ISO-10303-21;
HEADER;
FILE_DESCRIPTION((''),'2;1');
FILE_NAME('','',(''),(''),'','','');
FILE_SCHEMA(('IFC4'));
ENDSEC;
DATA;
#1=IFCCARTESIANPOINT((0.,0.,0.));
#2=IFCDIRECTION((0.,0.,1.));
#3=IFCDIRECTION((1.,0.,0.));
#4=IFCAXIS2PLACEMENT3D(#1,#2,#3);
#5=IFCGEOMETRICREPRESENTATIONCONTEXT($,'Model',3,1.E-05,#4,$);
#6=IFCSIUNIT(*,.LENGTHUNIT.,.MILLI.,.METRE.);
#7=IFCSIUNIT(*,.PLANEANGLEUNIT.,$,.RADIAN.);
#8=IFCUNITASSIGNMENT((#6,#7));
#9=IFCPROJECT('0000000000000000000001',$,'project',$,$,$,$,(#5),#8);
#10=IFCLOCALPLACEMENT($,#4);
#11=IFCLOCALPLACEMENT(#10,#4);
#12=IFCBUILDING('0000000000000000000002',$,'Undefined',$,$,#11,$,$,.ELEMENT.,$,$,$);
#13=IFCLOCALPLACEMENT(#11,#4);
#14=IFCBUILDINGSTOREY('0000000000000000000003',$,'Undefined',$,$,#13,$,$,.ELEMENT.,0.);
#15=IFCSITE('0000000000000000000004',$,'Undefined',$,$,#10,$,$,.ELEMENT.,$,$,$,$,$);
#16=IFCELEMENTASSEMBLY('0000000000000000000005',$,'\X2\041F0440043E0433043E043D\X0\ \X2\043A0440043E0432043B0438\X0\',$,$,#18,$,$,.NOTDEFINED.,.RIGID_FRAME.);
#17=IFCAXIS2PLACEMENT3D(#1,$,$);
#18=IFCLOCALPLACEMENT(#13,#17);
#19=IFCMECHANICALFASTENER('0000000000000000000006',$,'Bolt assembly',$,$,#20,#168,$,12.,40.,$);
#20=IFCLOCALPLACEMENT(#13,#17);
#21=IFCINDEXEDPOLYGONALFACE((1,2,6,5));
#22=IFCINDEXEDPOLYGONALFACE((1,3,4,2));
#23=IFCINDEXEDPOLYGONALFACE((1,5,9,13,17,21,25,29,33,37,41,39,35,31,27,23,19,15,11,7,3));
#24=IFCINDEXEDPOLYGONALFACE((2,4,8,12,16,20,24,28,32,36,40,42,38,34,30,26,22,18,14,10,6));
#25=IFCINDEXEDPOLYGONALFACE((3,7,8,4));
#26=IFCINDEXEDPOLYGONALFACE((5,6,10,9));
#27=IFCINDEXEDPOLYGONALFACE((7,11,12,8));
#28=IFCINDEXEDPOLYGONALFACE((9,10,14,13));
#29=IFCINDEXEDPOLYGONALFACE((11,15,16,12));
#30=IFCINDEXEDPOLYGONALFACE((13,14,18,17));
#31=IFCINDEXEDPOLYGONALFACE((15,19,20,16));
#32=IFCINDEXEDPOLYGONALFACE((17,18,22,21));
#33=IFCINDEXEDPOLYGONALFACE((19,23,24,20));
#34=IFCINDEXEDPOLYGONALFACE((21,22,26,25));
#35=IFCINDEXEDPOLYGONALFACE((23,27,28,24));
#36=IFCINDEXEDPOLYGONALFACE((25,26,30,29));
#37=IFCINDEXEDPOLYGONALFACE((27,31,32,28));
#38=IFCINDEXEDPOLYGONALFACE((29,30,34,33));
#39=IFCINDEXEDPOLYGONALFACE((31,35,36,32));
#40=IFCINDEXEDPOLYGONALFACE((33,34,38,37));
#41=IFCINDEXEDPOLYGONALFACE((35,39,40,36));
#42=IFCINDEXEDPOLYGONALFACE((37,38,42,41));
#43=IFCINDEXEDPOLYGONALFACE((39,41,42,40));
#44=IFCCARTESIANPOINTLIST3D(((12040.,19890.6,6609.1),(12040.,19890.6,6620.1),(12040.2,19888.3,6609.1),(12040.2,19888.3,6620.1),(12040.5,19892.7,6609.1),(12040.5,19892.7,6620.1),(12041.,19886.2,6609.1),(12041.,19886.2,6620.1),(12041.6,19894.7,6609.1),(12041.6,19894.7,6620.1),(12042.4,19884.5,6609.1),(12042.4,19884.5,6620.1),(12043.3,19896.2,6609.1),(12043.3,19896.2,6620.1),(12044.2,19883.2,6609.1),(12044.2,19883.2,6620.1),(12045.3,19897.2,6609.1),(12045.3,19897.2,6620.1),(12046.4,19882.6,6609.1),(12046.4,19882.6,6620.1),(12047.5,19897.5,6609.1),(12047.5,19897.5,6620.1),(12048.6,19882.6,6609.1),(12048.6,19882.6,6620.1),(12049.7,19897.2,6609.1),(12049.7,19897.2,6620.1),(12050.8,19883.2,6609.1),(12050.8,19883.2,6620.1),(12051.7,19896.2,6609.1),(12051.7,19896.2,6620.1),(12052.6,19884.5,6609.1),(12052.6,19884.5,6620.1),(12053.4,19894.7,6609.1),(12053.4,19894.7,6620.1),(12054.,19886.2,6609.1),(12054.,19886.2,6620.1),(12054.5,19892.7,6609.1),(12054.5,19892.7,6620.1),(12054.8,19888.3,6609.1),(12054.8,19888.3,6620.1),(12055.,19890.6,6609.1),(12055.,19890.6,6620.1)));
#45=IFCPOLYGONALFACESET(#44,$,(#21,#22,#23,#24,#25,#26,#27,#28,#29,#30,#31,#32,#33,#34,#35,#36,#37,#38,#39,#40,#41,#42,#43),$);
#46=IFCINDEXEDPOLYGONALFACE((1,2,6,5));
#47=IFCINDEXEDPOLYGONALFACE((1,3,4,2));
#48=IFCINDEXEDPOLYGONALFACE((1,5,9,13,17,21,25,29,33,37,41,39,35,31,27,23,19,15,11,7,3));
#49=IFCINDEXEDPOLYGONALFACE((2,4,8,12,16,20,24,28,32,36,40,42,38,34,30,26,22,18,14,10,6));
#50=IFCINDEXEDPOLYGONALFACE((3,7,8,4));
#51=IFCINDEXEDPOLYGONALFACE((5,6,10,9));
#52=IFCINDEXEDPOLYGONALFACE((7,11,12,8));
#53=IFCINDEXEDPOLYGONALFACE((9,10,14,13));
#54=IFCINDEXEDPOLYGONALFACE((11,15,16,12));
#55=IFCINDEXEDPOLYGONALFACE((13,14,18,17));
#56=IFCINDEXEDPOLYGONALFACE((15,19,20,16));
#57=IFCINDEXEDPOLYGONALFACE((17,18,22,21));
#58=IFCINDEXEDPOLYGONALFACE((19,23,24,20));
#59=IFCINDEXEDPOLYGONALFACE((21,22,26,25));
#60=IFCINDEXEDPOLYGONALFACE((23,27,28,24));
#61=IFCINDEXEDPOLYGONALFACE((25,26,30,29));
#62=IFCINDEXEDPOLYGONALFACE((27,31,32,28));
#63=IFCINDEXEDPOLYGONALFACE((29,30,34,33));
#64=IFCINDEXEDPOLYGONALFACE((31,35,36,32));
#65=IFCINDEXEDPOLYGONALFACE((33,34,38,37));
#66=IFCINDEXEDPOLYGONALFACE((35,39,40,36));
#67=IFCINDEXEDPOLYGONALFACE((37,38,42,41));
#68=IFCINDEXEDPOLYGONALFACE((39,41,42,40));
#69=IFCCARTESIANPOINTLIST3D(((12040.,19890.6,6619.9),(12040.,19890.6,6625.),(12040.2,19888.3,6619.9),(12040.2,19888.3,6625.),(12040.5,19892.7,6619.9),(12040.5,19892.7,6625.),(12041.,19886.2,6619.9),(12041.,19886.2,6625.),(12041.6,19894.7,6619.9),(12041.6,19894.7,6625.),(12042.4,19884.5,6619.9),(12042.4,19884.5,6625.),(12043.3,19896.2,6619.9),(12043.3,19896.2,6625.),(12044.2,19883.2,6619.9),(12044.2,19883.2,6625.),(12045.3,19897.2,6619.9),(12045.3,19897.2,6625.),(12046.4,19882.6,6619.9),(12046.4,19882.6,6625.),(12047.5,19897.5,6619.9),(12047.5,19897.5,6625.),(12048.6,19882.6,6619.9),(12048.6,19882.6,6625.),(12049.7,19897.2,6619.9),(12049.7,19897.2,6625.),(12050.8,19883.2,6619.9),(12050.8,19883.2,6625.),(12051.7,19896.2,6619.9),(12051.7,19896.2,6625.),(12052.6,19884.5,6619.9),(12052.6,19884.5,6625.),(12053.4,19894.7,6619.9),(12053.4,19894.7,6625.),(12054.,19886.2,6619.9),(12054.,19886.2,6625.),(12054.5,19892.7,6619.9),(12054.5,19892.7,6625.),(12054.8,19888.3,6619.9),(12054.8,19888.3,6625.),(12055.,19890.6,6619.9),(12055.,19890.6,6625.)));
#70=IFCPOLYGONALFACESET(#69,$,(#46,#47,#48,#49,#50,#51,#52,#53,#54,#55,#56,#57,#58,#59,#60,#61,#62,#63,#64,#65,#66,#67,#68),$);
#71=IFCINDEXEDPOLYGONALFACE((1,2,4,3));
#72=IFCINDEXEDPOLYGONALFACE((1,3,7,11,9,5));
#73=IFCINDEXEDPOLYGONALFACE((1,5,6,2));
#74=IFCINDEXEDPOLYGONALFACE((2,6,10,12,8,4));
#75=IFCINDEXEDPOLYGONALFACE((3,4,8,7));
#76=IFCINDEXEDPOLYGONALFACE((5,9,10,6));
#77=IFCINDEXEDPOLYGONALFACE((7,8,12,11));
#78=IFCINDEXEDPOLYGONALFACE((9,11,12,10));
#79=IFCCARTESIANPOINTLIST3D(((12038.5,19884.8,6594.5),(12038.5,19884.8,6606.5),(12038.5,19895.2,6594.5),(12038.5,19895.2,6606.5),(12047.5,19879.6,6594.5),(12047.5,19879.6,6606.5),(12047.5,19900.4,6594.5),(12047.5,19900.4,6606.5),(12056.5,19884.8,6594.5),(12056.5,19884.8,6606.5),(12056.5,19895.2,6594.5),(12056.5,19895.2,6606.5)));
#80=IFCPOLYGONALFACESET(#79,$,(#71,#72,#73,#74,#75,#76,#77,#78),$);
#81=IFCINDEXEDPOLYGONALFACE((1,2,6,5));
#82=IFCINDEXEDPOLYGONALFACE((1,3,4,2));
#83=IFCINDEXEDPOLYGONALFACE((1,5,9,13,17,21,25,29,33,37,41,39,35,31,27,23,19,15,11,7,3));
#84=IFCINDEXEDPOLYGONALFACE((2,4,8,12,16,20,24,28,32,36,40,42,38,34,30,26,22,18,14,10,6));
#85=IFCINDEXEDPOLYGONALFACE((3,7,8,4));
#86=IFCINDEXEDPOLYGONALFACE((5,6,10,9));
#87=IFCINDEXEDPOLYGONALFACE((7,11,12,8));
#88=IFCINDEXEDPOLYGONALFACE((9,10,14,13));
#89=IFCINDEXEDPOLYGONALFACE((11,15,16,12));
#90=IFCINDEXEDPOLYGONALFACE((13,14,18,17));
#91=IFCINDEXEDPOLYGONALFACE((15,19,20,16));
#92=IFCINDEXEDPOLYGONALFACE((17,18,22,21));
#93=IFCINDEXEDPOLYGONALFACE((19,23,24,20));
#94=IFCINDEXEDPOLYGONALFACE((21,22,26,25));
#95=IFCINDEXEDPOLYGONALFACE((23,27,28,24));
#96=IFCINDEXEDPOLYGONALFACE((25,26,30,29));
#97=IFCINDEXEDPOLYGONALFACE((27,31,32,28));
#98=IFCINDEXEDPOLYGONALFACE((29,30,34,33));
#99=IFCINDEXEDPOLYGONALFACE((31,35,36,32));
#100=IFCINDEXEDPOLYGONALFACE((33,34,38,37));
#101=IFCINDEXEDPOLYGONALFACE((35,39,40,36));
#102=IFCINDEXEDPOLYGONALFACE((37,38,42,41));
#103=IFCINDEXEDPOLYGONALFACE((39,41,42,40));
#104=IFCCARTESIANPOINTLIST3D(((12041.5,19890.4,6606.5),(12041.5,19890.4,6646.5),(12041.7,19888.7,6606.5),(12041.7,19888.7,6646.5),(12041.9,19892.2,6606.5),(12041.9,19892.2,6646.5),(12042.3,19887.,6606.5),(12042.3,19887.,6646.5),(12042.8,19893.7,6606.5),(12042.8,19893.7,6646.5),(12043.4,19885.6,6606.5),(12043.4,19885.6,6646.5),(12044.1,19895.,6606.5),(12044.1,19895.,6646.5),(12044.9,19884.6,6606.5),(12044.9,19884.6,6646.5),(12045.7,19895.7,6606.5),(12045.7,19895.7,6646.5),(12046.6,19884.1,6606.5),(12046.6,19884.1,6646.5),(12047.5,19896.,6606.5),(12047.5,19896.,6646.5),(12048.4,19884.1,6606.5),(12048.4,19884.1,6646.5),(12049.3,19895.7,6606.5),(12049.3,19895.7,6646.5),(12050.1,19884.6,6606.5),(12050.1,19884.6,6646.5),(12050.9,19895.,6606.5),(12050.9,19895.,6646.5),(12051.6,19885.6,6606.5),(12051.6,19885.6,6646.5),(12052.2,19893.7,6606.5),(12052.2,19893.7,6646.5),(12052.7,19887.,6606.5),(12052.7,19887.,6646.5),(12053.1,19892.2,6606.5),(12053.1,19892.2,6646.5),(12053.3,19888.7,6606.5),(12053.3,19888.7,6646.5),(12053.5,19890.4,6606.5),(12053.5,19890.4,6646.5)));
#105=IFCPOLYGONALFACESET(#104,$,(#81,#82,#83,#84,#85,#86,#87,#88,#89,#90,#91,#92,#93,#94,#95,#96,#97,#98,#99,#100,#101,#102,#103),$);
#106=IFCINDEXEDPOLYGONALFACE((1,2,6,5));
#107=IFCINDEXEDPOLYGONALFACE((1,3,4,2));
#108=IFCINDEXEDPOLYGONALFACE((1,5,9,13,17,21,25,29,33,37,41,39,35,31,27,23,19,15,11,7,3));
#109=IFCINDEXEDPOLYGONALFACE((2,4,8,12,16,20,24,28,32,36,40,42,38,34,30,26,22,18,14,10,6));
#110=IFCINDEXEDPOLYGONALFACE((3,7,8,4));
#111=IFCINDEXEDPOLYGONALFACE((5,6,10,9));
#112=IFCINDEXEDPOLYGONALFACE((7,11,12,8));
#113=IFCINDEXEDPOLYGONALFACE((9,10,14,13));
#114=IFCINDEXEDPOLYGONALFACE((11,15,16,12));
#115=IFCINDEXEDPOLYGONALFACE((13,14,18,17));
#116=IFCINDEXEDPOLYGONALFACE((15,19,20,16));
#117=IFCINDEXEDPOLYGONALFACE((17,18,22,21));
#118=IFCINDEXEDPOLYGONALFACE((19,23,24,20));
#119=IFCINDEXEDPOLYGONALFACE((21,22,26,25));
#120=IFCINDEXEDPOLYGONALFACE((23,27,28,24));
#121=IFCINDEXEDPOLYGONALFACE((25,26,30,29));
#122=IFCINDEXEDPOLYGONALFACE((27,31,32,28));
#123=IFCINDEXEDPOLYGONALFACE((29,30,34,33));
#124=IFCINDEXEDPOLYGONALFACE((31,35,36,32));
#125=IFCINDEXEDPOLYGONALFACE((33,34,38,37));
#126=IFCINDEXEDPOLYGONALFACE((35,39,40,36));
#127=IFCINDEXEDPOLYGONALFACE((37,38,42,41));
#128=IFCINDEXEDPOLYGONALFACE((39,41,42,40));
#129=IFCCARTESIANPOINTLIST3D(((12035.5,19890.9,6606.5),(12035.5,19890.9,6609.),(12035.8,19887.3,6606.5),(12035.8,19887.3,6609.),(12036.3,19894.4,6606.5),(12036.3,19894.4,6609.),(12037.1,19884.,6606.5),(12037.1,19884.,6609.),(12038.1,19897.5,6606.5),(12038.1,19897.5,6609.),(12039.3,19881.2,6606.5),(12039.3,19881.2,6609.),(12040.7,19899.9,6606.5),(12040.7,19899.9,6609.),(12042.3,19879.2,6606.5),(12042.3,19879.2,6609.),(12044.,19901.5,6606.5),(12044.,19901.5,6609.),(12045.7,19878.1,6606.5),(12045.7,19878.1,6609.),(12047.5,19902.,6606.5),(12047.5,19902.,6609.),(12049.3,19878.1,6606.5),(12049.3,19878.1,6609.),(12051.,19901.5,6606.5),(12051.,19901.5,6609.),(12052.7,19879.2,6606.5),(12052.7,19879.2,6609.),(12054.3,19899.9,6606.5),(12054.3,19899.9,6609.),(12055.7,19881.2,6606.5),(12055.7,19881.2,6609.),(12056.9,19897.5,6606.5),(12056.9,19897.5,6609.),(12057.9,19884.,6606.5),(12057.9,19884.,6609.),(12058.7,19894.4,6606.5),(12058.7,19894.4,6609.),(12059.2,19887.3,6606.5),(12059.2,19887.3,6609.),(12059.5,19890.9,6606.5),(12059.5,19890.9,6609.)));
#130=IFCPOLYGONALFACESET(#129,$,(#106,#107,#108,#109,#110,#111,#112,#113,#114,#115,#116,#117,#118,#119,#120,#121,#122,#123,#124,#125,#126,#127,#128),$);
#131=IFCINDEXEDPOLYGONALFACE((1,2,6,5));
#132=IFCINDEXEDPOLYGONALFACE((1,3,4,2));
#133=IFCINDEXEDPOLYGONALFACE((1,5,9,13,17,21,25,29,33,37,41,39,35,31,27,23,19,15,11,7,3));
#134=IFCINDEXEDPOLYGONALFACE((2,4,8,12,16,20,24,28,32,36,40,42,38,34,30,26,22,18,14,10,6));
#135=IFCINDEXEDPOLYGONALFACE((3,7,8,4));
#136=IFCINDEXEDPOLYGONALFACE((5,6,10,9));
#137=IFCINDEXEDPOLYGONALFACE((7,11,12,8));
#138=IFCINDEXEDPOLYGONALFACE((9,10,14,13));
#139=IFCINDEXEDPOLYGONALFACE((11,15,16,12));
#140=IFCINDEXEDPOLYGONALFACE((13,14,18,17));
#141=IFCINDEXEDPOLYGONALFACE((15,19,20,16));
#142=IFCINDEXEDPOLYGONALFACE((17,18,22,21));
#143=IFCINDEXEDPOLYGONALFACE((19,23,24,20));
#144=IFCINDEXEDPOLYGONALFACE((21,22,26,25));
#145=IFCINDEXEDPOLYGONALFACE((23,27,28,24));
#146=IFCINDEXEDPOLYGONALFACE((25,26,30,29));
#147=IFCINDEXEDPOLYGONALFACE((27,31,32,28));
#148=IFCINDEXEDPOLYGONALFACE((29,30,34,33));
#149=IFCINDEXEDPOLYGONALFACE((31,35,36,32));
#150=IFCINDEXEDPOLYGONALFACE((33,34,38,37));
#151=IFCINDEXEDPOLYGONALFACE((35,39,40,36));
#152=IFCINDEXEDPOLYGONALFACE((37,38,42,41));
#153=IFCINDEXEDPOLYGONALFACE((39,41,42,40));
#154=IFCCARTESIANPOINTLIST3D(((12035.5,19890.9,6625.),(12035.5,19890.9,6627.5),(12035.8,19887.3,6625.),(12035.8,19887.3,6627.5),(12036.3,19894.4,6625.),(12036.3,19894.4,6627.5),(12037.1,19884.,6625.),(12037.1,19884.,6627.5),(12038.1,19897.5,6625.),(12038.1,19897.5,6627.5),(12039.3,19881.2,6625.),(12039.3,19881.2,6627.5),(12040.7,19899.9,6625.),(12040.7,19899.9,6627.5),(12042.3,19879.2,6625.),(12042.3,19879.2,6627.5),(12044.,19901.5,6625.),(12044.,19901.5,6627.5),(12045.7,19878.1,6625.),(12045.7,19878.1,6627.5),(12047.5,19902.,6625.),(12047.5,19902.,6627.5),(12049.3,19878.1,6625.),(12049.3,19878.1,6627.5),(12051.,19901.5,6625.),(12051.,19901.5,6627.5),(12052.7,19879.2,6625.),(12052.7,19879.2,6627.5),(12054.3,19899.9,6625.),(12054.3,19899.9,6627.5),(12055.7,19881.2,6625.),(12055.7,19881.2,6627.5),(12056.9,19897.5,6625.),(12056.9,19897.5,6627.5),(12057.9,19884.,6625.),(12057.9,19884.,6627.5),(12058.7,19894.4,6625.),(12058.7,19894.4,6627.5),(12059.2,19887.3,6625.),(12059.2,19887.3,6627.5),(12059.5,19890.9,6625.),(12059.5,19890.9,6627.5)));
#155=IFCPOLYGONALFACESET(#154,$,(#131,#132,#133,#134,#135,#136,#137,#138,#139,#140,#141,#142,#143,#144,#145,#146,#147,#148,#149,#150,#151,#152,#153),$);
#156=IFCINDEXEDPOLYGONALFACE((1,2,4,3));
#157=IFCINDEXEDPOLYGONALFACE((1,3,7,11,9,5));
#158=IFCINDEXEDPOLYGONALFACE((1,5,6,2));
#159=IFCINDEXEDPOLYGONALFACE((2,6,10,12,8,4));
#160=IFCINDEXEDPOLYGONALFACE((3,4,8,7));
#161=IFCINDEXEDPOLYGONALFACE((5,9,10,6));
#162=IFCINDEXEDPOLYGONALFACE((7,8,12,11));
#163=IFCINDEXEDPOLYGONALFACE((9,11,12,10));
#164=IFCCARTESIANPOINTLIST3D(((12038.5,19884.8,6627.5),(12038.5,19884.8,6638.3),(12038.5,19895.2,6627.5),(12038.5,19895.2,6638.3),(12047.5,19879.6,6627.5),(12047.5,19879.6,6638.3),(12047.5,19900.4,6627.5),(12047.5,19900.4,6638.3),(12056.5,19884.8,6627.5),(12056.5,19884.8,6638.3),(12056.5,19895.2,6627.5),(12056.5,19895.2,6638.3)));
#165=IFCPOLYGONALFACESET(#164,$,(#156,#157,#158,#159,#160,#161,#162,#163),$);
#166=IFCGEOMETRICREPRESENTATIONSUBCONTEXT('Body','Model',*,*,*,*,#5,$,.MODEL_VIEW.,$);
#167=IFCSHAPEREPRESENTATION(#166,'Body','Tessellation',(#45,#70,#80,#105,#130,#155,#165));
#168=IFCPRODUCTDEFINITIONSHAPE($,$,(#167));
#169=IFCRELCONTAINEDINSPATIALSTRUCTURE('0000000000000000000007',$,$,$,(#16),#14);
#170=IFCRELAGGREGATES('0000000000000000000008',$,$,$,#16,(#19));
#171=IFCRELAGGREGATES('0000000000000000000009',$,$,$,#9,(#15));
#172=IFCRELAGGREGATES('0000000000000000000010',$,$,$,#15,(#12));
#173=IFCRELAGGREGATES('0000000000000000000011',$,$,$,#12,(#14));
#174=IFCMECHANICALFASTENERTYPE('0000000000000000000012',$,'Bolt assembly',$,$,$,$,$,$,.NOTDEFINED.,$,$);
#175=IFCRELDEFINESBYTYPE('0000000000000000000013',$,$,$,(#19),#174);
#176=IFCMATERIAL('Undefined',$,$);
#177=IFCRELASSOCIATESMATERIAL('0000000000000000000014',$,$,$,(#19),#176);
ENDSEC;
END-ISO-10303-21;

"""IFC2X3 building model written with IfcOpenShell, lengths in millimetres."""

from ifc_helpers import new_model, si_unit, frame, origin_with_axes, origin_2d_with_axis, place, context, subcontext, project, spatial, polyline, circle, outline, extrude, source, transform, mapped, material, type_object, element, aggregate, save


model = new_model("IFC2X3")

# Units and contexts
model_context = context("Model", 3, precision=1e-05, world=origin_with_axes())
body_context = subcontext(model_context, "Body", "Model", "MODEL_VIEW")
ifc_project = project(units=[si_unit("LENGTHUNIT", "METRE", prefix="MILLI"), si_unit("PLANEANGLEUNIT", "RADIAN")], contexts=[model_context])

# Site, building, storey
site_placement = place(None, origin_with_axes())
site = spatial("IfcSite", under=ifc_project, at=site_placement, Name="Undefined", CompositionType="ELEMENT")
building_placement = place(site_placement, origin_with_axes())
building = spatial("IfcBuilding", under=site, at=building_placement, Name="Undefined", CompositionType="ELEMENT")
storey_placement = place(building_placement, origin_with_axes())
storey = spatial("IfcBuildingStorey", under=building, at=storey_placement, Name="Undefined", CompositionType="ELEMENT", Elevation=0.0)

# Element assembly, mechanical fastener
assembly_1_placement = place(storey_placement, origin_with_axes())
assembly_1 = element("IfcElementAssembly", 1, at=assembly_1_placement, inside=storey, Name="Прогон кровли", AssemblyPlace="NOTDEFINED", PredefinedType="RIGID_FRAME")
ifc_material_1 = material(Name="Undefined")
mechanical_fastener_type = type_object("IfcMechanicalFastenerType", Name="Bolt assembly")
shared_shape_1 = source(origin_with_axes(), body_context, "Body", "SweptSolid", [
    extrude(circle(Radius=7.5, at=origin_2d_with_axis()), frame((0.0, -10.9, 0.0), z_axis=(0.0, 1.0, 0.0), x_axis=(1.0, 0.0, 0.0)), (0.0, 0.0, 1.0), 11.0),
    extrude(circle(Radius=7.5, at=origin_2d_with_axis()), frame((0.0, -0.1, 0.0), z_axis=(0.0, 1.0, 0.0), x_axis=(1.0, 0.0, 0.0)), (0.0, 0.0, 1.0), 5.1),
    extrude(outline(polyline([(10.4, 0.0), (5.2, 9.0), (-5.2, 9.0), (-10.4, 0.0), (-5.2, -9.0), (5.2, -9.0), (10.4, 0.0)])), frame((0.0, -25.5, 0.0), z_axis=(0.0, 1.0, 0.0), x_axis=(1.0, 0.0, 0.0)), (0.0, 0.0, 1.0), 12.0),
    extrude(circle(Radius=6.0, at=origin_2d_with_axis()), frame((0.0, -13.5, 0.0), z_axis=(0.0, 1.0, 0.0), x_axis=(1.0, 0.0, 0.0)), (0.0, 0.0, 1.0), 40.0),
    extrude(circle(Radius=12.0, at=origin_2d_with_axis()), frame((0.0, -13.5, 0.0), z_axis=(0.0, 1.0, 0.0), x_axis=(1.0, 0.0, 0.0)), (0.0, 0.0, 1.0), 2.5),
    extrude(circle(Radius=12.0, at=origin_2d_with_axis()), frame((0.0, 5.0, 0.0), z_axis=(0.0, 1.0, 0.0), x_axis=(1.0, 0.0, 0.0)), (0.0, 0.0, 1.0), 2.5),
    extrude(outline(polyline([(10.4, 0.0), (5.2, 9.0), (-5.2, 9.0), (-10.4, 0.0), (-5.2, -9.0), (5.2, -9.0), (10.4, 0.0)])), frame((0.0, 7.5, 0.0), z_axis=(0.0, 1.0, 0.0), x_axis=(1.0, 0.0, 0.0)), (0.0, 0.0, 1.0), 10.8),
])
mechanical_fastener_1_placement = place(assembly_1_placement, frame((12047.5, 19890.0, 6620.0), z_axis=(1.0, 0.0, 0.0), x_axis=(0.0, 1.0, 0.0)))
mechanical_fastener_1 = element("IfcMechanicalFastener", 2, at=mechanical_fastener_1_placement, type_object=mechanical_fastener_type, material=ifc_material_1, Name="Bolt assembly", NominalDiameter=12.0, NominalLength=40.0, context=body_context, shape_type="MappedRepresentation", body=[
    mapped(shared_shape_1, transform((0.0, 0.0, 0.0))),
])
aggregate(assembly_1, [mechanical_fastener_1])

save(model, "model.ifc")
